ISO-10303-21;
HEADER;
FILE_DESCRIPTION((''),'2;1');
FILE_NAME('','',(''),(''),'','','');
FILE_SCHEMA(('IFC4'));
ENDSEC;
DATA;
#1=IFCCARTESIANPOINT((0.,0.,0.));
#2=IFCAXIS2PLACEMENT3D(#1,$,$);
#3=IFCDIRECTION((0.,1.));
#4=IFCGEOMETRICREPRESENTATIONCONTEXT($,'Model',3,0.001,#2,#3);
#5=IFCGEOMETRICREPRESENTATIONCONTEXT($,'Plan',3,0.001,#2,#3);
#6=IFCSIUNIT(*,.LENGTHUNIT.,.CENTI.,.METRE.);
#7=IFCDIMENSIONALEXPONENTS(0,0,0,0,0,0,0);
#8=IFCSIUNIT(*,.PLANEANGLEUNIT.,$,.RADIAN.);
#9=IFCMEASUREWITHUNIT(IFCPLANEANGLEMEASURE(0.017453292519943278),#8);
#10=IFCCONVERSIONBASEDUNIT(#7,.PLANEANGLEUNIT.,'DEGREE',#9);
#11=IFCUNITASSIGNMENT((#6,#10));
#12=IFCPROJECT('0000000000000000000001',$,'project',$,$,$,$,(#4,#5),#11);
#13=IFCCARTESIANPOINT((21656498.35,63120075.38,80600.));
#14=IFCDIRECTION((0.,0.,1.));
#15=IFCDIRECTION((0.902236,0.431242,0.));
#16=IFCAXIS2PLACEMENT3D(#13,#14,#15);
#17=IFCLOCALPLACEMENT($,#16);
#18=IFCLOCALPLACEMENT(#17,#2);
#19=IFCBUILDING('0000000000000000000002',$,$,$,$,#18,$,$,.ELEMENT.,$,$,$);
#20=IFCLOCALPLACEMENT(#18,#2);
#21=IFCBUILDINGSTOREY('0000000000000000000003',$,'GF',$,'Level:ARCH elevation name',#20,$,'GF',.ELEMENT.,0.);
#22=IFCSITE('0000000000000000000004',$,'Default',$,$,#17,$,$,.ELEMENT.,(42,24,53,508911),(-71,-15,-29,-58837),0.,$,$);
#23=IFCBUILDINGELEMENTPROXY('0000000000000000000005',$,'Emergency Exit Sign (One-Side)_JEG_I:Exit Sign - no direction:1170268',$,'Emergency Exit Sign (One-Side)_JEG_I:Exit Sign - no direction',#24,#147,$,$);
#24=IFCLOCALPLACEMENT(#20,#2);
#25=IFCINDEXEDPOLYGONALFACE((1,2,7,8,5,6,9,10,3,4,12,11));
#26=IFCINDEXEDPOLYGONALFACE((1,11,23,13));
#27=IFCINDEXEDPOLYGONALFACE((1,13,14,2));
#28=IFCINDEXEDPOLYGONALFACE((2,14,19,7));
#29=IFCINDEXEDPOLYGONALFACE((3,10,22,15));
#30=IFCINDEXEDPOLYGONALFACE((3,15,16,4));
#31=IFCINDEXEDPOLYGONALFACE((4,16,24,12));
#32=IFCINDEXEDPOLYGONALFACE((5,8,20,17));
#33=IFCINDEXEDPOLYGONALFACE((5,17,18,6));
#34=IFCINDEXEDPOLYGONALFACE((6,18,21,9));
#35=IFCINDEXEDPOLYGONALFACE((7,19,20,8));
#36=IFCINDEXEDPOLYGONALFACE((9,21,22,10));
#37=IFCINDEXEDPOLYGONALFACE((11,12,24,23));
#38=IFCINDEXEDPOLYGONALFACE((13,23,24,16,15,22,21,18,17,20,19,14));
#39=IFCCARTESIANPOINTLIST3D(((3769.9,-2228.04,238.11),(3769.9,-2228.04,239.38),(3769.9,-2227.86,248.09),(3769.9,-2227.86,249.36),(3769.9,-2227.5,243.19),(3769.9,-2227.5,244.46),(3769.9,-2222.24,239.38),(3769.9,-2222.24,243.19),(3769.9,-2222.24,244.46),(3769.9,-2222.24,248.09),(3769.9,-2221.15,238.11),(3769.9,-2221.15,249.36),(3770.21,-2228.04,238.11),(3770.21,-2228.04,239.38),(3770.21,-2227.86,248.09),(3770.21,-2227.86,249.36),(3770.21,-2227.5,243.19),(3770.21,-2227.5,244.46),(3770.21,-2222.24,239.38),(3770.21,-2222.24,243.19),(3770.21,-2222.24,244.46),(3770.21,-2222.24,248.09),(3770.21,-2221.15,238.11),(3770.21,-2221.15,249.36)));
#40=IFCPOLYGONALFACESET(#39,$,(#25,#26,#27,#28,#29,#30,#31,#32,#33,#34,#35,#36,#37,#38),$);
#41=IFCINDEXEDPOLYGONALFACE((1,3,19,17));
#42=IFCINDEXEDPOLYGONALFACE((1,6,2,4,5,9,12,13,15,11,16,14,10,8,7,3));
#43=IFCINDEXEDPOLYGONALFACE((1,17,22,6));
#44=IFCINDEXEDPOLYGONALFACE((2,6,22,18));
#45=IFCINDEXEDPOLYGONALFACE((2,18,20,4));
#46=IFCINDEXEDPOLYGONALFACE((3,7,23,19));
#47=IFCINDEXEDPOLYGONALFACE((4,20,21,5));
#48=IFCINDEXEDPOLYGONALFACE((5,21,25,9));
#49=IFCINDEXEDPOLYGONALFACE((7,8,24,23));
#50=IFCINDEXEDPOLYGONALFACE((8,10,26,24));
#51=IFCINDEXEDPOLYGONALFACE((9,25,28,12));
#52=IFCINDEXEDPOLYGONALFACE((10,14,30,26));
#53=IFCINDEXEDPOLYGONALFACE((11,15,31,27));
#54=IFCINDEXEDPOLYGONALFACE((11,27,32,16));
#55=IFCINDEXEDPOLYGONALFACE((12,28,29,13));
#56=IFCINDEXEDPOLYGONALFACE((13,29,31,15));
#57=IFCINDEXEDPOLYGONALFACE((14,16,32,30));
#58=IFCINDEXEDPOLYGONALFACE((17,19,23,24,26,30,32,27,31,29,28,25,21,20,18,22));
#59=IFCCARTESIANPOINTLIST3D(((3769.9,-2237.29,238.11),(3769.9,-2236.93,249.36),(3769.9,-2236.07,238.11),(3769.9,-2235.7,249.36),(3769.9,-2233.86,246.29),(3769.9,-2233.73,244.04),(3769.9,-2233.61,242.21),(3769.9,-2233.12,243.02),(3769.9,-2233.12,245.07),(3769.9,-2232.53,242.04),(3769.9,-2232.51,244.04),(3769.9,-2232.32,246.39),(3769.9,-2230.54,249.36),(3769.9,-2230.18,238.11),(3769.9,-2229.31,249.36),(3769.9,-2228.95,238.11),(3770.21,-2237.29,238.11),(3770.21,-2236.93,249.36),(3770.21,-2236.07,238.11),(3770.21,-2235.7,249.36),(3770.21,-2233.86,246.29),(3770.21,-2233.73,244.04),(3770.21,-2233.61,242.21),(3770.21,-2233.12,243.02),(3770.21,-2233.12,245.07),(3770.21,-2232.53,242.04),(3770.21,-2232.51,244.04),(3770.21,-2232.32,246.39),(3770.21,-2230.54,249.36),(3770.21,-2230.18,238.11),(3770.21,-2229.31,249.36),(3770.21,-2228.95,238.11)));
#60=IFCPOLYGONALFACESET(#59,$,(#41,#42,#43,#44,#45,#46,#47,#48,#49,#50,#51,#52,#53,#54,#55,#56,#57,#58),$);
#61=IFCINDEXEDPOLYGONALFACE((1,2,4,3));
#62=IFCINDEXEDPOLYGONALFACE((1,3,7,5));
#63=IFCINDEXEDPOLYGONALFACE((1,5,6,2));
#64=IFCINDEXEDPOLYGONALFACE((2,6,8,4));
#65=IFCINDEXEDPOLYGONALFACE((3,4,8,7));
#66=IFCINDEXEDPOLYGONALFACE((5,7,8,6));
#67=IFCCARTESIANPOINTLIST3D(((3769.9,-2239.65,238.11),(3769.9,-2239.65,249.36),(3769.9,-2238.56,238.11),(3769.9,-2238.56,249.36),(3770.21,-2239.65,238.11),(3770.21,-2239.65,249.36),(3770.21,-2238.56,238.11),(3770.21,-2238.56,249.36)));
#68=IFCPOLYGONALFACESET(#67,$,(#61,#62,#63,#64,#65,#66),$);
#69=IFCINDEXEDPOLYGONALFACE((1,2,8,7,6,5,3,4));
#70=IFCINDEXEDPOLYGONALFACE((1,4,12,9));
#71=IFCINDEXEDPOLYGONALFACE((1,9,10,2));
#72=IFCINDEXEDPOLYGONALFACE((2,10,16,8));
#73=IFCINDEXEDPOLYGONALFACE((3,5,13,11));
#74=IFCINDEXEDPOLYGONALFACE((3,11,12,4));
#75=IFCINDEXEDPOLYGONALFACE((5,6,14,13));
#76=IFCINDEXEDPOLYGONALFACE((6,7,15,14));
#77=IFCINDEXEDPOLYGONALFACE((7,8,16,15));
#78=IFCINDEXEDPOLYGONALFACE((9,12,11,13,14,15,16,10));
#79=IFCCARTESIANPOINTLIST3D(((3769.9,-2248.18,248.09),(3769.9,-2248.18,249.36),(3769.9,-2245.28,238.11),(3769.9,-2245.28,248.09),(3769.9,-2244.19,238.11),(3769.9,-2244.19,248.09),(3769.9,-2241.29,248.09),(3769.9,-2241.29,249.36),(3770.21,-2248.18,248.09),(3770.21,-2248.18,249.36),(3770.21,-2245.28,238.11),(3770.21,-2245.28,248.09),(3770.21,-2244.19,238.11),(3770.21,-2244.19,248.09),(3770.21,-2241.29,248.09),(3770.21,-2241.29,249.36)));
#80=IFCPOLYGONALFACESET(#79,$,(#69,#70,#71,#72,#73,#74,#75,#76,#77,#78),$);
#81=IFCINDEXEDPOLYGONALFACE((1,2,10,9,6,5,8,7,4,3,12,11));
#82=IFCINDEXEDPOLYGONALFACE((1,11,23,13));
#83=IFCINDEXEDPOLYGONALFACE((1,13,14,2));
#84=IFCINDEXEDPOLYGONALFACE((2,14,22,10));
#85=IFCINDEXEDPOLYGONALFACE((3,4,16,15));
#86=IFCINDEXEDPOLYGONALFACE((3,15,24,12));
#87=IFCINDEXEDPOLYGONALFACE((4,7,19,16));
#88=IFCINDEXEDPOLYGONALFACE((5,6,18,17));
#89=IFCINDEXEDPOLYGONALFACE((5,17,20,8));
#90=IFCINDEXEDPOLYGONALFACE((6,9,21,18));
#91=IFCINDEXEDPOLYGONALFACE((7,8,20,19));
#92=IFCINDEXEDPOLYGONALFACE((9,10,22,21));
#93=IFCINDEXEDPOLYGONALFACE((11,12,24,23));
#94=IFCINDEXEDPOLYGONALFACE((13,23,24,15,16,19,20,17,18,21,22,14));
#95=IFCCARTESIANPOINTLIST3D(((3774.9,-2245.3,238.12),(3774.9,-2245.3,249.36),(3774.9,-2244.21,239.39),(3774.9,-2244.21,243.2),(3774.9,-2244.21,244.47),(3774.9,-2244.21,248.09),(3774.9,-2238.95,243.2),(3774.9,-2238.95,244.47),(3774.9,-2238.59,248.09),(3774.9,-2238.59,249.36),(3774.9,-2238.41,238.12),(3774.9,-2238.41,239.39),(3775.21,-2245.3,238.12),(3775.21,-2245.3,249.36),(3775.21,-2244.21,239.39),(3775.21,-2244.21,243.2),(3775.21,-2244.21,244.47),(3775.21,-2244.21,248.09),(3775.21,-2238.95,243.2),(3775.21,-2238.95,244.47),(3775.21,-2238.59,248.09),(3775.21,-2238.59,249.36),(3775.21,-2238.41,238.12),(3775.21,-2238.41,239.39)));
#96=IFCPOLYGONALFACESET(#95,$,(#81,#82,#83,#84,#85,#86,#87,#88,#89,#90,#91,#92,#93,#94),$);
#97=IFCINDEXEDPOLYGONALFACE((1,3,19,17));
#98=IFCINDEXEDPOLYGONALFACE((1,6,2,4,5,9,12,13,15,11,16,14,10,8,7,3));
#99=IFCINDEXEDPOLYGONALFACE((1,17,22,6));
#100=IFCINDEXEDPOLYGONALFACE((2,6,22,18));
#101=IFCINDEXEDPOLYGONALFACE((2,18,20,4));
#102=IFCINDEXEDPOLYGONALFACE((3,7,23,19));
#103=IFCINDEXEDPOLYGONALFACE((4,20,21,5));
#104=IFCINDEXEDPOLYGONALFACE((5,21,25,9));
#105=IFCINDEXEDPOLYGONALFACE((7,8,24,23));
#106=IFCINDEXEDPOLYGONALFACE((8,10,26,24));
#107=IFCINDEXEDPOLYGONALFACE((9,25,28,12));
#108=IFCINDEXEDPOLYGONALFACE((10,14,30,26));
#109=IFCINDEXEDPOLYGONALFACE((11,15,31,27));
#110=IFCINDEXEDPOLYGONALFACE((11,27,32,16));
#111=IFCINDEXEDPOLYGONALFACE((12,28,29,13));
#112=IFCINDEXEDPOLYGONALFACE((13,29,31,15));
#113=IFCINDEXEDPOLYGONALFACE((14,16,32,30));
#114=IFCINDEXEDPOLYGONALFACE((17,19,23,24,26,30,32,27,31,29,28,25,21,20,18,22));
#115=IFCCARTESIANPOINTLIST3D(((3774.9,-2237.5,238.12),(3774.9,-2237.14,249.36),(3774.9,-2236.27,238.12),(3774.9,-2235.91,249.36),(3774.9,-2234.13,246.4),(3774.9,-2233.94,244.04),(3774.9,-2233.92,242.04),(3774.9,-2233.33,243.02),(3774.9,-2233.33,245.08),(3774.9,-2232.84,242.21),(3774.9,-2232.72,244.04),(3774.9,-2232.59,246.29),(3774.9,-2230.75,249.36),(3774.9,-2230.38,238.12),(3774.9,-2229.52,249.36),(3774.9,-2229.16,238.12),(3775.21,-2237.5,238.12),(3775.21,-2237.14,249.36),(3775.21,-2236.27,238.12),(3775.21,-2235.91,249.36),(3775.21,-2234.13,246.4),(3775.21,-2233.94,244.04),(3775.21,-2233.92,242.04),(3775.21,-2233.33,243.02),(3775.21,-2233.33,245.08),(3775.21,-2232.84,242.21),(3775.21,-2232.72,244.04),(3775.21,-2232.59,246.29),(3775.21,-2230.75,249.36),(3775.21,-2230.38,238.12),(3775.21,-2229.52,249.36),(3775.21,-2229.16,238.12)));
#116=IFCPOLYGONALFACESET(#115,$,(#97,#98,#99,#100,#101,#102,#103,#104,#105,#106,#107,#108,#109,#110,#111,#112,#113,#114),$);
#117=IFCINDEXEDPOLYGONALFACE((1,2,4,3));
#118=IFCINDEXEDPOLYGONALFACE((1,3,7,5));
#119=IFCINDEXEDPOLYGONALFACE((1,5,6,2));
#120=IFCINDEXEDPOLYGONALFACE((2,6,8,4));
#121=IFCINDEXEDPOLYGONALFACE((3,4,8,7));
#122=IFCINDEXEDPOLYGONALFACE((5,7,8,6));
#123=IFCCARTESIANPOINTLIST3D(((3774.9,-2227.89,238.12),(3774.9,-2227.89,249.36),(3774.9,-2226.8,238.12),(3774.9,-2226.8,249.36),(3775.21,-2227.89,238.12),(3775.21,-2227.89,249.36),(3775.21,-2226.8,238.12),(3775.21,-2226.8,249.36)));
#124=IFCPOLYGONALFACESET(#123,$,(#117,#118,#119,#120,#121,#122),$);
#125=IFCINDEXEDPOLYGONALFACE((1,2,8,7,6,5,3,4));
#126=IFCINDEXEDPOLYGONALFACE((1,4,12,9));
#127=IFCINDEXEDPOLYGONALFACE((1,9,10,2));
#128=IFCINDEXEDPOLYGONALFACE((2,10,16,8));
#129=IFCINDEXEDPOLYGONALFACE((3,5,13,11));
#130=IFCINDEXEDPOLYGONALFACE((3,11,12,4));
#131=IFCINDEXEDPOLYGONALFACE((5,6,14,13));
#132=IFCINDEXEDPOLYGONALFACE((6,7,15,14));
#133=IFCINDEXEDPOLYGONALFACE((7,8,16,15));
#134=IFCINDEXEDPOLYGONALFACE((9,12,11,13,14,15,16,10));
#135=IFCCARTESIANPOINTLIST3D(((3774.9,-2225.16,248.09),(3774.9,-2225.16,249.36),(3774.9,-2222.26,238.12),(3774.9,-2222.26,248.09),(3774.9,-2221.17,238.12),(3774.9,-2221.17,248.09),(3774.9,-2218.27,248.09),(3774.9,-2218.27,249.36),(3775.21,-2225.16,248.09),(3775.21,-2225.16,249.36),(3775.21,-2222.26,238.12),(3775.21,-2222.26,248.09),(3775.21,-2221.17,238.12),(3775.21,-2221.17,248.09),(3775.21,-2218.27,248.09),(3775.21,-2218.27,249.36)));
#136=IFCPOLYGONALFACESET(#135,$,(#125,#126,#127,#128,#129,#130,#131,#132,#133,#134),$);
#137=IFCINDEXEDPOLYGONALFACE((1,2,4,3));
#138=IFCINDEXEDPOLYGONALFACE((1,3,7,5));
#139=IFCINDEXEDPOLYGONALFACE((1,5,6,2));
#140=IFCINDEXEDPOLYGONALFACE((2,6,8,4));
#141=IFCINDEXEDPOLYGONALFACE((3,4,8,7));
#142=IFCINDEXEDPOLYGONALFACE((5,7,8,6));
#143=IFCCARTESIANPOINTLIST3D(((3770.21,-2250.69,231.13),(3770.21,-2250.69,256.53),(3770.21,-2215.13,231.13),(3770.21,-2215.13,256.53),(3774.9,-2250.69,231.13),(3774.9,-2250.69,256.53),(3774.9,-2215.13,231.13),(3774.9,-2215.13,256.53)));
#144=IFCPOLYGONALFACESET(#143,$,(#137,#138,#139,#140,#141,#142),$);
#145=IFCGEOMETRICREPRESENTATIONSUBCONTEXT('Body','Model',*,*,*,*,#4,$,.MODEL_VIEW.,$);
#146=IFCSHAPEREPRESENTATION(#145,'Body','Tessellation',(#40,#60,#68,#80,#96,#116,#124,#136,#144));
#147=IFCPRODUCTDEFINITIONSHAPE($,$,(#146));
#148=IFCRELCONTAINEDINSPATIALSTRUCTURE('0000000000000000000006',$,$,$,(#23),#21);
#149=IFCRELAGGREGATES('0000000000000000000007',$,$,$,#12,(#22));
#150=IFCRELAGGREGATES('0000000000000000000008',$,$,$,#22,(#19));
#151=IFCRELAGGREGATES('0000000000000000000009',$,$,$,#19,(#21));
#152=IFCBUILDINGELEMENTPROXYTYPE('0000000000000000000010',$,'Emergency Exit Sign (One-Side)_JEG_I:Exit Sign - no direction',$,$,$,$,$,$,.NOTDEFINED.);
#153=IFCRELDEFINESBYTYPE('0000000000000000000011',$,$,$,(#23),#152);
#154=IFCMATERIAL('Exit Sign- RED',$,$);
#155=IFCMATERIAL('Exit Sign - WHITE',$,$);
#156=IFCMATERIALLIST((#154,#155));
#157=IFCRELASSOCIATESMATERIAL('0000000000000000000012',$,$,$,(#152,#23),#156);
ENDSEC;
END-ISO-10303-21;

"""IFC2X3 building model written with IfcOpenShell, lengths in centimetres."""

from ifc_helpers import new_model, entity, si_unit, converted_unit, direction, frame, frame_2d, origin, origin_2d_with_axis, place, context, subcontext, project, spatial, polyline, rectangle, outline, extrude, source, transform, mapped, material, material_list, type_object, type_shapes, element, save


model = new_model("IFC2X3")

# Units and contexts
model_context = context("Model", 3, precision=0.001, world=origin(), true_north=direction((0.0, 1.0)))
plan_context = context("Plan", 3, precision=0.001, world=origin(), true_north=direction((0.0, 1.0)))
body_context = subcontext(model_context, "Body", "Model", "MODEL_VIEW")
ifc_project = project(units=[si_unit("LENGTHUNIT", "METRE", prefix="CENTI"), converted_unit("PLANEANGLEUNIT", "DEGREE", entity("IfcPlaneAngleMeasure", 0.017453292519943278), si_unit("PLANEANGLEUNIT", "RADIAN"), dimensions=[0, 0, 0, 0, 0, 0, 0])], contexts=[model_context, plan_context])

# Site, building, storey
site_placement = place(None, frame((21656498.35, 63120075.38, 80600.0), z_axis=(0.0, 0.0, 1.0), x_axis=(0.902236, 0.431242, 0.0)))
site = spatial("IfcSite", under=ifc_project, at=site_placement, Name="Default", CompositionType="ELEMENT", RefLatitude=(42, 24, 53, 508911), RefLongitude=(-71, -15, -29, -58837), RefElevation=0.0)
building_placement = place(site_placement, origin())
building = spatial("IfcBuilding", under=site, at=building_placement, CompositionType="ELEMENT")
storey_placement = place(building_placement, origin())
storey = spatial("IfcBuildingStorey", under=building, at=storey_placement, Name="GF", ObjectType="Level:ARCH elevation name", LongName="GF", CompositionType="ELEMENT", Elevation=0.0)

# Building element proxy
ifc_material_1 = material(Name="Exit Sign- RED")
ifc_material_2 = material(Name="Exit Sign - WHITE")
ifc_material_list_1 = material_list([ifc_material_1, ifc_material_2])
building_element_proxy_type_1 = type_object("IfcBuildingElementProxyType", Name="Emergency Exit Sign (One-Side)_JEG_I:Exit Sign - no direction", PredefinedType="NOTDEFINED", material=ifc_material_list_1)
shared_shape_1 = source(origin(), body_context, "Body", "SweptSolid", [
    extrude(outline(polyline([(-5.65, -3.69), (5.59, -3.69), (5.59, 3.02), (4.32, 3.02), (4.32, -2.6), (0.7, -2.6), (0.7, 2.66), (-0.57, 2.66), (-0.57, -2.6), (-4.38, -2.6), (-4.38, 3.21), (-5.65, 3.21), (-5.65, -3.69)])), frame((-8.08, -5.22, 12.64), z_axis=(0.0, 1.0, 0.0), x_axis=(0.0, 0.0, 1.0)), (0.0, 0.0, 1.0), 0.32),
    extrude(outline(polyline([(-7.14, 0.57), (-6.5, -0.49), (-1.93, -0.48), (-0.78, -0.48), (-1.23, -1.32), (-3.47, -5.53), (-2.84, -6.59), (0.41, -0.48), (6.62, -0.48), (5.99, 0.57), (2.4, 0.57), (0.98, 0.58), (1.7, 1.94), (3.32, 5.0), (2.69, 6.05), (-0.22, 0.57), (-7.14, 0.57)])), frame((0.2, -5.22, 12.81), z_axis=(0.0, -1.0, 0.0), x_axis=(0.515099, 0.0, 0.857131)), (0.0, 0.0, -1.0), 0.32),
    extrude(rectangle(XDim=0.32, YDim=1.09, at=frame_2d((0.0, 0.0), x_axis=(1.0, 0.0))), frame((6.19, -5.06, 6.99), z_axis=(0.0, 0.0, 1.0), x_axis=(0.0, 1.0, 0.0)), (0.0, 0.0, 1.0), 11.25),
    extrude(outline(polyline([(-7.8, 0.54), (-7.8, -0.54), (2.18, -0.54), (2.18, -3.45), (3.45, -3.45), (3.45, 3.45), (2.18, 3.45), (2.18, 0.54), (-7.8, 0.54)])), frame((11.82, -5.22, 14.79), z_axis=(0.0, -1.0, 0.0), x_axis=(0.0, 0.0, 1.0)), (0.0, 0.0, -1.0), 0.32),
    extrude(outline(polyline([(-3.69, -5.65), (3.21, -5.65), (3.21, -4.38), (-2.6, -4.38), (-2.6, -0.57), (2.66, -0.57), (2.66, 0.7), (-2.6, 0.7), (-2.6, 4.32), (3.02, 4.32), (3.02, 5.59), (-3.69, 5.59), (-3.69, -5.65)])), frame((8.7, -0.22, 12.65), z_axis=(0.0, 1.0, 0.0), x_axis=(-1.0, 0.0, 0.0)), (0.0, 0.0, 1.0), 0.32),
    extrude(outline(polyline([(-4.16, -5.82), (-2.93, -5.82), (-0.58, -1.9), (0.01, -0.92), (0.5, -1.73), (2.96, -5.82), (4.18, -5.82), (0.62, 0.1), (3.82, 5.42), (2.59, 5.42), (0.75, 2.35), (0.01, 1.14), (-0.79, 2.46), (-2.57, 5.42), (-3.8, 5.42), (-0.6, 0.1), (-4.16, -5.82)])), frame((0.43, -0.22, 12.82), z_axis=(0.0, 1.0, 0.0), x_axis=(-1.0, 0.0, 0.0)), (0.0, 0.0, 1.0), 0.32),
    extrude(rectangle(XDim=0.32, YDim=1.09, at=origin_2d_with_axis()), frame((-5.57, -0.06, 6.99), z_axis=(0.0, 0.0, 1.0), x_axis=(0.0, -1.0, 0.0)), (0.0, 0.0, 1.0), 11.25),
    extrude(outline(polyline([(-0.54, -7.8), (0.54, -7.8), (0.54, 2.18), (3.45, 2.18), (3.45, 3.45), (-3.45, 3.45), (-3.45, 2.18), (-0.54, 2.18), (-0.54, -7.8)])), frame((-11.2, -0.22, 14.79), z_axis=(0.0, 1.0, 0.0), x_axis=(-1.0, 0.0, 0.0)), (0.0, 0.0, 1.0), 0.32),
    extrude(rectangle(XDim=4.68, YDim=35.56, at=origin_2d_with_axis()), frame((0.0, -2.56, 0.01), z_axis=(0.0, 0.0, 1.0), x_axis=(0.0, 1.0, 0.0)), (0.0, 0.0, 1.0), 25.4),
])
type_shapes(building_element_proxy_type_1, [shared_shape_1])
for number, where, z_axis, x_axis, name in (
    (1, (3775.12, -2232.91, 231.12), (0.0, 0.0, 1.0), (0.0, -1.0, 0.0), "Emergency Exit Sign (One-Side)_JEG_I:Exit Sign - no direction:1170268"),
):
    element("IfcBuildingElementProxy", number, at=place(storey_placement, frame(where, z_axis=z_axis, x_axis=x_axis)), inside=storey, type_object=building_element_proxy_type_1, material=ifc_material_list_1, Name=name, ObjectType="Emergency Exit Sign (One-Side)_JEG_I:Exit Sign - no direction", context=body_context, shape_type="MappedRepresentation", body=[
        mapped(shared_shape_1, transform((0.0, 0.0, 0.0), scale=1.0)),
    ])

save(model, "model.ifc")
